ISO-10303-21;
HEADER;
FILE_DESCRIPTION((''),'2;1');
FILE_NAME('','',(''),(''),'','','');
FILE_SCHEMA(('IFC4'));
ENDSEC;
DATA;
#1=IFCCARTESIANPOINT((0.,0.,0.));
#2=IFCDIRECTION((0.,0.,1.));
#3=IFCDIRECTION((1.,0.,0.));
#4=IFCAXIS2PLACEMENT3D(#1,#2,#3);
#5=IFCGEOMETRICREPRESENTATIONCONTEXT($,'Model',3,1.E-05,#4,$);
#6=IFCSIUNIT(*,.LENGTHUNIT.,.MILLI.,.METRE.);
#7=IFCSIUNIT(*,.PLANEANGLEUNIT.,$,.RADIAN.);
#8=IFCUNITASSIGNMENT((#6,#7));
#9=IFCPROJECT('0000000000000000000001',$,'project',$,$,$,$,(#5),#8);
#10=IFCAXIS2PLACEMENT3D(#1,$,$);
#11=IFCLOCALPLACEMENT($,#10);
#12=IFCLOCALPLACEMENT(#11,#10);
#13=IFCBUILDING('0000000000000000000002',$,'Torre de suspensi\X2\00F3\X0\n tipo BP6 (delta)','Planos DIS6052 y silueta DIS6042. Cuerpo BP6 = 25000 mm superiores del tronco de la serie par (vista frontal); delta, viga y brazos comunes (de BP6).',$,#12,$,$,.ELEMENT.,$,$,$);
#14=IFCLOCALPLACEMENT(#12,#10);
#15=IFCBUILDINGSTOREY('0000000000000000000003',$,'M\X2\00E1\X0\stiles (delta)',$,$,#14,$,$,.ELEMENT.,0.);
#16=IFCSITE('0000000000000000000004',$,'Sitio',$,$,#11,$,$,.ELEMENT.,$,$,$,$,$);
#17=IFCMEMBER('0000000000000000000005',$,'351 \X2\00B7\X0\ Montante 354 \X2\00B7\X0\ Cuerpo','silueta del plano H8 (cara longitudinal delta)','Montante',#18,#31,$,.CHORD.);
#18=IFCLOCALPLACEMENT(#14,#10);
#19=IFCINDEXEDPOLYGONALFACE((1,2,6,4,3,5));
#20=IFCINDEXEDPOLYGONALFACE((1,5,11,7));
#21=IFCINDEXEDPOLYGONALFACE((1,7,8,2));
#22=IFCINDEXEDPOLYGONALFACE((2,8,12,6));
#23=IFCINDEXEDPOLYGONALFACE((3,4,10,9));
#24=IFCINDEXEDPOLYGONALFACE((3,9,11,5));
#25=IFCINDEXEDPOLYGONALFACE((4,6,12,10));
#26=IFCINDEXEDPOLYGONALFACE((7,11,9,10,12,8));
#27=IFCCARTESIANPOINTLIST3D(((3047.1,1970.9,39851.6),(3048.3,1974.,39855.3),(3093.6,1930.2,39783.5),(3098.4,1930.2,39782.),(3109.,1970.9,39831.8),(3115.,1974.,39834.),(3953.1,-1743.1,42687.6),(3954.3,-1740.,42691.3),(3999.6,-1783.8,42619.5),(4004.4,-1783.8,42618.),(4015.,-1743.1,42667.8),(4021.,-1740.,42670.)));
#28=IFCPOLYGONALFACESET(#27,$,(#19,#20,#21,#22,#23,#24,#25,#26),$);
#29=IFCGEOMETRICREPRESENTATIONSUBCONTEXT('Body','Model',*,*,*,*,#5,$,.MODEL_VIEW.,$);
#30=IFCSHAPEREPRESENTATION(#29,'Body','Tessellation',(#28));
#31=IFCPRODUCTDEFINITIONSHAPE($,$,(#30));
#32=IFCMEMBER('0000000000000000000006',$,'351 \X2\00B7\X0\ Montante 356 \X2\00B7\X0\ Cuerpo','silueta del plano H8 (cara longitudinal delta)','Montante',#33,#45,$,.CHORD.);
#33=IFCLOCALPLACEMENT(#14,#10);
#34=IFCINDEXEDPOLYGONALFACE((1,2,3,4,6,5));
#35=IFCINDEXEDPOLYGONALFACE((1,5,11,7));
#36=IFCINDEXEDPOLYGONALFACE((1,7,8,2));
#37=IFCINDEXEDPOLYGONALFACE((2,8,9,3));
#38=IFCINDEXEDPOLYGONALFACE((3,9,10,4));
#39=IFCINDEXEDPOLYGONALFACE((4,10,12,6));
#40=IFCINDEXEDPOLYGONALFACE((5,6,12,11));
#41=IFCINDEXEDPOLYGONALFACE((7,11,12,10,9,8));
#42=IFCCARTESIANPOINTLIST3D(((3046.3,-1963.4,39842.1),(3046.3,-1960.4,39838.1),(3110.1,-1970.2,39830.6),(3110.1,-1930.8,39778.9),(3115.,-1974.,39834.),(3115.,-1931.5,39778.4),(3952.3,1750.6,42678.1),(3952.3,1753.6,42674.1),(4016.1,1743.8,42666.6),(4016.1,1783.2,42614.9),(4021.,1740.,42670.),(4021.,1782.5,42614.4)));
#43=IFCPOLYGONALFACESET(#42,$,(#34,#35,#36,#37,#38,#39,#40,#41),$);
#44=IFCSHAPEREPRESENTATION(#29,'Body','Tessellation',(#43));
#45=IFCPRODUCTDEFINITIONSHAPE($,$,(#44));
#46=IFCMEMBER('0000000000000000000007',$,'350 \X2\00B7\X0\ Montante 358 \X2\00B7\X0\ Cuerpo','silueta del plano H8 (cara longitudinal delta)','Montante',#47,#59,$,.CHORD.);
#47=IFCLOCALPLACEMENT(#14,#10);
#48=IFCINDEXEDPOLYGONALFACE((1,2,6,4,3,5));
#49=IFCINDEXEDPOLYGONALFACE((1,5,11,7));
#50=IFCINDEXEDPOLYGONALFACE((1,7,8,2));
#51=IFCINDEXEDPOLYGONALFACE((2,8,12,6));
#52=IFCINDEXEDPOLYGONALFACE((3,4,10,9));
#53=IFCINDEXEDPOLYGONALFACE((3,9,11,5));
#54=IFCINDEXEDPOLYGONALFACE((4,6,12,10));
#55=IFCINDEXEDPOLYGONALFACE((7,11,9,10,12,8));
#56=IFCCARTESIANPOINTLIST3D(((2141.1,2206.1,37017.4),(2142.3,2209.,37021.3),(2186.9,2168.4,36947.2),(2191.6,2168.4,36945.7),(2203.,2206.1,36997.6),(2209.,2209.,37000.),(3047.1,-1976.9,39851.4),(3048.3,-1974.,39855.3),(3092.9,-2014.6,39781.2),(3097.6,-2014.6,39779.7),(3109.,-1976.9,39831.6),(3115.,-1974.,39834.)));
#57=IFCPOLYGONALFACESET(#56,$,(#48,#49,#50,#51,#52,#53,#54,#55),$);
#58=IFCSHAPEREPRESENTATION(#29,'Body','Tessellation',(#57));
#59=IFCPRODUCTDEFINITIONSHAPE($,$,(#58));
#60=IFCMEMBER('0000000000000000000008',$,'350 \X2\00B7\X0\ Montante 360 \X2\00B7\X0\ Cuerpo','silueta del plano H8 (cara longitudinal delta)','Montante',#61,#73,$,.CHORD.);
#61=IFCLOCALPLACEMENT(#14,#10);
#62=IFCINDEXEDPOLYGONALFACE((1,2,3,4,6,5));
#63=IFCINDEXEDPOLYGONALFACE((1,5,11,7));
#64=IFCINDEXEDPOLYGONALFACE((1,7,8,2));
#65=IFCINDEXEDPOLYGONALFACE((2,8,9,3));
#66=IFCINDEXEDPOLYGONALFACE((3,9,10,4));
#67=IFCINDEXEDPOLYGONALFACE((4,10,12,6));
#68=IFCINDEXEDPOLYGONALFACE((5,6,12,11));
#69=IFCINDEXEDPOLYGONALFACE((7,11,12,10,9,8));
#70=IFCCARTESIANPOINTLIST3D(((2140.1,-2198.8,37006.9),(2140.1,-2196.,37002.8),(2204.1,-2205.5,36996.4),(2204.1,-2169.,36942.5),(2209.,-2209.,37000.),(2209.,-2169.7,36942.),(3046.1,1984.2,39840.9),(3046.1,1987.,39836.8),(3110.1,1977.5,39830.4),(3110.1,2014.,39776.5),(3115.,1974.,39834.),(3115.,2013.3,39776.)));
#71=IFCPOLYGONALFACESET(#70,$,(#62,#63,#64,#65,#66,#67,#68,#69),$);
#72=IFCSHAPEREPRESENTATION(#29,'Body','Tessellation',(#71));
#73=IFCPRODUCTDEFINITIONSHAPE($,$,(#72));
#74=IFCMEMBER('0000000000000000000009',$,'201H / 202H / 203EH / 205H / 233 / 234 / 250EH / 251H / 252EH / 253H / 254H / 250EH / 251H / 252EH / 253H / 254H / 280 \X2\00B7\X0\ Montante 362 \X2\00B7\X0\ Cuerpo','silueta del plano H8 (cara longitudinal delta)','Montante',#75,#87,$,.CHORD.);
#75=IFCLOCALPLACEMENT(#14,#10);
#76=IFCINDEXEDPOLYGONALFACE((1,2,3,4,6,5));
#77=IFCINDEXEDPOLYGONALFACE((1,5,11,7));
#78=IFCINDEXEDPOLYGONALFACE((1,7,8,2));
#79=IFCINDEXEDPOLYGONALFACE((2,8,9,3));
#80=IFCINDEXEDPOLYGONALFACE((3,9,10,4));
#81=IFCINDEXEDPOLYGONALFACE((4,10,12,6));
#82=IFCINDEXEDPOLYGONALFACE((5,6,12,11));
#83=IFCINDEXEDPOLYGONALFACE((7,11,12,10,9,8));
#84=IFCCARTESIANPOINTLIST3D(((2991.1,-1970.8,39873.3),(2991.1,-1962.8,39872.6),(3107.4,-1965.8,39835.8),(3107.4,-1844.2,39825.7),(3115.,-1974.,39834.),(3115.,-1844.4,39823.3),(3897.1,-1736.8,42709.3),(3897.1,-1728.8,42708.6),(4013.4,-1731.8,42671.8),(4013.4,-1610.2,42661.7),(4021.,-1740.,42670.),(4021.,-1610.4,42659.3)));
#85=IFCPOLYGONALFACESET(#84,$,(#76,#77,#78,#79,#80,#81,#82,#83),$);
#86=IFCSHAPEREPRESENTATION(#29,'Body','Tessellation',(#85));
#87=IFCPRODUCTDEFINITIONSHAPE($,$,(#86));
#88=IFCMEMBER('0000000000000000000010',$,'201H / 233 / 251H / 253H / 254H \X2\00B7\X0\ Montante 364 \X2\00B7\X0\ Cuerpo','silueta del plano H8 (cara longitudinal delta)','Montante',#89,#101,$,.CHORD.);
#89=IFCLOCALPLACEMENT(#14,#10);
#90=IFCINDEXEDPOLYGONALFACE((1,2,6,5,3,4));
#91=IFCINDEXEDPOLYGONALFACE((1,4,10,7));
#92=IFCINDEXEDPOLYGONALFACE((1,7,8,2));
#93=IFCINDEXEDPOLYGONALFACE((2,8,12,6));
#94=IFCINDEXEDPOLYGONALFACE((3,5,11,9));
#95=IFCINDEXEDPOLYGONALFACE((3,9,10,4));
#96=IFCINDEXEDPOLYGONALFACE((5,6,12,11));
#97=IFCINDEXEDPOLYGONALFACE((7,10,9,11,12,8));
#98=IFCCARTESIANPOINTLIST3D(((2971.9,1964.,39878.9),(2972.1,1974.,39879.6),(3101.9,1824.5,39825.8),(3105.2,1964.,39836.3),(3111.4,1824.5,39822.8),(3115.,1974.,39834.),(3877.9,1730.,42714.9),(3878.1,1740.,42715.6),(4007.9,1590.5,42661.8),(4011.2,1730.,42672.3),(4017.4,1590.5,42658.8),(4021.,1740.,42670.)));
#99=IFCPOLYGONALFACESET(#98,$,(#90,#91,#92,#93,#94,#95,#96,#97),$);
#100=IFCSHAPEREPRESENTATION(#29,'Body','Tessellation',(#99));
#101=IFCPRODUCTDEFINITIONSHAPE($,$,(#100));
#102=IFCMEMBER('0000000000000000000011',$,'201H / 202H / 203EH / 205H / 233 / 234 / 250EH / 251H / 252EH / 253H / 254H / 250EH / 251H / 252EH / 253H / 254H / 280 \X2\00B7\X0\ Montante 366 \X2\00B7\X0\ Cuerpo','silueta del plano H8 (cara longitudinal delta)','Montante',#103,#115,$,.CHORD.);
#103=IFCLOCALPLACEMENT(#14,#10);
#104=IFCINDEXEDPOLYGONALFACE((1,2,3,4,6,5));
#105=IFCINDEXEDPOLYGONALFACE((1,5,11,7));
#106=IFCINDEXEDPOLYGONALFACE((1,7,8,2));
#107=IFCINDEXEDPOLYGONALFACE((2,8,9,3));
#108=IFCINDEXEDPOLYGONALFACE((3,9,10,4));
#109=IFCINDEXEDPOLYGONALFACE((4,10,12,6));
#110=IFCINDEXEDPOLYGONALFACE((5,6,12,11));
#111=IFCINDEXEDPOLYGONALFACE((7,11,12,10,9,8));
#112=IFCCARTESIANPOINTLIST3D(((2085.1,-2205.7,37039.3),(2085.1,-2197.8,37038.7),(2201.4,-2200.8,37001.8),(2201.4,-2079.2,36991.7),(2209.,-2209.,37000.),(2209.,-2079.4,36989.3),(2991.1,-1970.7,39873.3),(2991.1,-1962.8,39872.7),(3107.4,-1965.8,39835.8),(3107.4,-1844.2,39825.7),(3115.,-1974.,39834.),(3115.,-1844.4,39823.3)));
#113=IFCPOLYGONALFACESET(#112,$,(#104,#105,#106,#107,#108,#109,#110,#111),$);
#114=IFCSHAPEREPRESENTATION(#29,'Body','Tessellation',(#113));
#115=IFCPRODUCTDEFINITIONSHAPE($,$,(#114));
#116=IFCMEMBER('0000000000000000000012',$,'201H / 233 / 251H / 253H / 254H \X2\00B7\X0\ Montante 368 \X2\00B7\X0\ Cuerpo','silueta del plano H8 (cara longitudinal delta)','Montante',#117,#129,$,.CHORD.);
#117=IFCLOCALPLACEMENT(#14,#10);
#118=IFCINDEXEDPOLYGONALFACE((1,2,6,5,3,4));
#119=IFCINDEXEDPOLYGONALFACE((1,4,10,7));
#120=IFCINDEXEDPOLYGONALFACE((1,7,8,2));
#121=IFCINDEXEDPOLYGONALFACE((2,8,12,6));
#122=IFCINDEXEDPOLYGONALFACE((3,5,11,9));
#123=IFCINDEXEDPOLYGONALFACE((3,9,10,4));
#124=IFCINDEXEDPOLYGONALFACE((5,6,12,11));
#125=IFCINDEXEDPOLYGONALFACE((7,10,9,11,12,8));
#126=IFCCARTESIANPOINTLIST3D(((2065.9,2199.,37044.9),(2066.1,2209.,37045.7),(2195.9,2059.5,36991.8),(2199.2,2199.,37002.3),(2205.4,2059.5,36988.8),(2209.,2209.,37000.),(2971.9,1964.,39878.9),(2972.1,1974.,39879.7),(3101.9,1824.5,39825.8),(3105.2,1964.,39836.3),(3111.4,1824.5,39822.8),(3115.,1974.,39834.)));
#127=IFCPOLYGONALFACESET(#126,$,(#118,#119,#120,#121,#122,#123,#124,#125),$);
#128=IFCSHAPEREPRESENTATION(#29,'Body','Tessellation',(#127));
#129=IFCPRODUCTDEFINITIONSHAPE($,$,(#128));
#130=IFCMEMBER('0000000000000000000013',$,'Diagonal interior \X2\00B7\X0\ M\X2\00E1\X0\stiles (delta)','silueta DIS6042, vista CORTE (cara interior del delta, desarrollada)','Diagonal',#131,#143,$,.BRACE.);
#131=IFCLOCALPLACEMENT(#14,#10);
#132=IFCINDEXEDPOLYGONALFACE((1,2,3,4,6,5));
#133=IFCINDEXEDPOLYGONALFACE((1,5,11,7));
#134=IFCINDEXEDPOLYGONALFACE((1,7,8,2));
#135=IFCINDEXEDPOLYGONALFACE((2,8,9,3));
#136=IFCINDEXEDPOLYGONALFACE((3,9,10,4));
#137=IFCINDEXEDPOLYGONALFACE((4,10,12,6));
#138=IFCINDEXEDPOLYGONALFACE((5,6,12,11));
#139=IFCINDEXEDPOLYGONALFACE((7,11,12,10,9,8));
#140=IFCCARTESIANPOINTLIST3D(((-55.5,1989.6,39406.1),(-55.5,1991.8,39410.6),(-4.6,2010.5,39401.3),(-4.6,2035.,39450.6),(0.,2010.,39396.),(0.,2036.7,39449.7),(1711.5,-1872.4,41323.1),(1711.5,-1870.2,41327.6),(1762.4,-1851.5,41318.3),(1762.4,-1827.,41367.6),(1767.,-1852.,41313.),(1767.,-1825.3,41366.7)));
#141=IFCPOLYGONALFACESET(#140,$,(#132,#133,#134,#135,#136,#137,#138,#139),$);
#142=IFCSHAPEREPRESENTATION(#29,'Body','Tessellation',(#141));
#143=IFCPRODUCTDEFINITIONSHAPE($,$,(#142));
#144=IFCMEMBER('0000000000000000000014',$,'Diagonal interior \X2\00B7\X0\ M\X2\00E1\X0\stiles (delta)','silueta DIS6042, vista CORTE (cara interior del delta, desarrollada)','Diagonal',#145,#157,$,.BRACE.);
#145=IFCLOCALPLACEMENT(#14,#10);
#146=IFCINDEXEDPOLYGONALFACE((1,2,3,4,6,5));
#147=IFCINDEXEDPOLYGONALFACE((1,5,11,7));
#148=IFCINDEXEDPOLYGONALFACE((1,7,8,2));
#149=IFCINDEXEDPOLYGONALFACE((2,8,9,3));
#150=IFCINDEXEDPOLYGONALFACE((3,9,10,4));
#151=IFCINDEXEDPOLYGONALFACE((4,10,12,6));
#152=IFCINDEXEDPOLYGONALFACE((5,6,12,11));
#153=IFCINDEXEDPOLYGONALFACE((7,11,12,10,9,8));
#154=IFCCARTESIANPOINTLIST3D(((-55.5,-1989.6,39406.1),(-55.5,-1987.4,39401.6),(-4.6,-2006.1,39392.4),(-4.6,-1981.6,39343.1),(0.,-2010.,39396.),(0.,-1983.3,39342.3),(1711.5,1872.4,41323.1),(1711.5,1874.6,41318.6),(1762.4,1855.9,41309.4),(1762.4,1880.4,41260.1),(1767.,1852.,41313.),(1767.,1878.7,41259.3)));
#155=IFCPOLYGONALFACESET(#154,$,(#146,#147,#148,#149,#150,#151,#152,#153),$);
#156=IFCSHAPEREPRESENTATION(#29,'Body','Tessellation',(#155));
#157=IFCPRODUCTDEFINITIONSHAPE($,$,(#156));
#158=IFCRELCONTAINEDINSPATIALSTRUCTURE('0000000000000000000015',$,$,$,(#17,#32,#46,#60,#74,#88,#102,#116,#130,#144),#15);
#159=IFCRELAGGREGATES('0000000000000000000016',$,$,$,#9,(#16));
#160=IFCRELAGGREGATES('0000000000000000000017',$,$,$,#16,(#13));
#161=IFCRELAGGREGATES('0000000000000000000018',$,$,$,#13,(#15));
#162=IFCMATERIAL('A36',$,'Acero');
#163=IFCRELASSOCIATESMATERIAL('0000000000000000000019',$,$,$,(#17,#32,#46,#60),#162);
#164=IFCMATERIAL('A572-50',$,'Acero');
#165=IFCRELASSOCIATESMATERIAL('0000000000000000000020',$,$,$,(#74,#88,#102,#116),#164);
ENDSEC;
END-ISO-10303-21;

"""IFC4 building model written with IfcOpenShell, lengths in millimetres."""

from ifc_helpers import new_model, si_unit, frame, frame_2d, origin, origin_with_axes, place, context, subcontext, project, spatial, l_section, extrude, material, element, save


model = new_model("IFC4")

# Units and contexts
model_context = context("Model", 3, precision=1e-05, world=origin_with_axes())
body_context = subcontext(model_context, "Body", "Model", "MODEL_VIEW")
ifc_project = project(units=[si_unit("LENGTHUNIT", "METRE", prefix="MILLI"), si_unit("PLANEANGLEUNIT", "RADIAN")], contexts=[model_context])

# Site, building, storey
site_placement = place(None, origin())
site = spatial("IfcSite", under=ifc_project, at=site_placement, Name="Sitio", CompositionType="ELEMENT")
building_placement = place(site_placement, origin())
building = spatial("IfcBuilding", under=site, at=building_placement, Name="Torre de suspensión tipo BP6 (delta)", Description="Planos DIS6052 y silueta DIS6042. Cuerpo BP6 = 25000 mm superiores del tronco de la serie par (vista frontal); delta, viga y brazos comunes (de BP6).", CompositionType="ELEMENT")
storey_placement = place(building_placement, origin())
storey = spatial("IfcBuildingStorey", under=building, at=storey_placement, Name="Mástiles (delta)", CompositionType="ELEMENT", Elevation=0.0)

# Members
ifc_material_1 = material(Name="A572-50", Category="Acero")
ifc_material_2 = material(Name="A36", Category="Acero")
for number, where, z_axis, x_axis, name in (
    (1, (4021.0, -1740.0, 42670.0), (-0.190336, 0.780253, -0.595799), (-0.237441, -0.625464, -0.743248), "351 · Montante 354 · Cuerpo"),
    (2, (4021.0, 1740.0, 42670.0), (-0.190336, -0.780253, -0.595799), (-0.981719, 0.151276, 0.115514), "351 · Montante 356 · Cuerpo"),
):
    element("IfcMember", number, at=place(storey_placement, frame(where, z_axis=z_axis, x_axis=x_axis)), inside=storey, material=ifc_material_2, Name=name, Description="silueta del plano H8 (cara longitudinal delta)", ObjectType="Montante", PredefinedType="CHORD", context=body_context, shape_type="SweptSolid", body=[
        extrude(l_section(Depth=70.0, Width=70.0, Thickness=5.0, at=frame_2d((35.0, 35.0))), None, (0.0, 0.0, 1.0), 4760.0),
    ])
for number, where, z_axis, x_axis, name in (
    (3, (3115.0, -1974.0, 39834.0), (-0.176498, 0.814889, -0.552091), (-0.24814, -0.579617, -0.77619), "350 · Montante 358 · Cuerpo"),
    (4, (3115.0, 1974.0, 39834.0), (-0.176498, -0.814889, -0.552091), (-0.984301, 0.14612, 0.098997), "350 · Montante 360 · Cuerpo"),
):
    element("IfcMember", number, at=place(storey_placement, frame(where, z_axis=z_axis, x_axis=x_axis)), inside=storey, material=ifc_material_2, Name=name, Description="silueta del plano H8 (cara longitudinal delta)", ObjectType="Montante", PredefinedType="CHORD", context=body_context, shape_type="SweptSolid", body=[
        extrude(l_section(Depth=70.0, Width=70.0, Thickness=5.0, at=frame_2d((35.0, 35.0))), None, (0.0, 0.0, 1.0), 5133.2),
    ])
member_1_placement = place(storey_placement, frame((4021.0, -1740.0, 42670.0), z_axis=(-0.303377, -0.078356, -0.949644), x_axis=(-0.952871, 0.024947, 0.302349)))
element("IfcMember", 5, at=member_1_placement, inside=storey, material=ifc_material_1, Name="201H / 202H / 203EH / 205H / 233 / 234 / 250EH / 251H / 252EH / 253H / 254H / 250EH / 251H / 252EH / 253H / 254H / 280 · Montante 362 · Cuerpo", Description="silueta del plano H8 (cara longitudinal delta)", ObjectType="Montante", PredefinedType="CHORD", context=body_context, shape_type="SweptSolid", body=[
    extrude(l_section(Depth=130.0, Width=130.0, Thickness=8.0, at=frame_2d((65.0, 65.0))), None, (0.0, 0.0, 1.0), 2986.4),
])
member_2_placement = place(storey_placement, frame((4021.0, 1740.0, 42670.0), z_axis=(-0.303377, 0.078356, -0.949644), x_axis=(-0.023845, -0.996925, -0.074639)))
element("IfcMember", 6, at=member_2_placement, inside=storey, material=ifc_material_1, Name="201H / 233 / 251H / 253H / 254H · Montante 364 · Cuerpo", Description="silueta del plano H8 (cara longitudinal delta)", ObjectType="Montante", PredefinedType="CHORD", context=body_context, shape_type="SweptSolid", body=[
    extrude(l_section(Depth=150.0, Width=150.0, Thickness=10.0, at=frame_2d((75.0, 75.0))), None, (0.0, 0.0, 1.0), 2986.4),
])
member_3_placement = place(storey_placement, frame((3115.0, -1974.0, 39834.0), z_axis=(-0.303562, -0.078738, -0.949553), x_axis=(-0.952812, 0.025086, 0.302524)))
element("IfcMember", 7, at=member_3_placement, inside=storey, material=ifc_material_1, Name="201H / 202H / 203EH / 205H / 233 / 234 / 250EH / 251H / 252EH / 253H / 254H / 250EH / 251H / 252EH / 253H / 254H / 280 · Montante 366 · Cuerpo", Description="silueta del plano H8 (cara longitudinal delta)", ObjectType="Montante", PredefinedType="CHORD", context=body_context, shape_type="SweptSolid", body=[
    extrude(l_section(Depth=130.0, Width=130.0, Thickness=8.0, at=frame_2d((65.0, 65.0))), None, (0.0, 0.0, 1.0), 2984.6),
])
member_4_placement = place(storey_placement, frame((3115.0, 1974.0, 39834.0), z_axis=(-0.303562, 0.078738, -0.949553), x_axis=(-0.023976, -0.996895, -0.074999)))
element("IfcMember", 8, at=member_4_placement, inside=storey, material=ifc_material_1, Name="201H / 233 / 251H / 253H / 254H · Montante 368 · Cuerpo", Description="silueta del plano H8 (cara longitudinal delta)", ObjectType="Montante", PredefinedType="CHORD", context=body_context, shape_type="SweptSolid", body=[
    extrude(l_section(Depth=150.0, Width=150.0, Thickness=10.0, at=frame_2d((75.0, 75.0))), None, (0.0, 0.0, 1.0), 2984.6),
])
for number, where, z_axis, x_axis, name in (
    (9, (1767.0, -1852.0, 41313.0), (-0.379214, 0.82882, -0.411405), (-0.925309, -0.33967, 0.168604), "Diagonal interior · Mástiles (delta)"),
    (10, (1767.0, 1852.0, 41313.0), (-0.379214, -0.82882, -0.411405), (-0.925309, 0.33967, 0.168604), "Diagonal interior · Mástiles (delta)"),
):
    element("IfcMember", number, at=place(storey_placement, frame(where, z_axis=z_axis, x_axis=x_axis)), inside=storey, Name=name, Description="silueta DIS6042, vista CORTE (cara interior del delta, desarrollada)", ObjectType="Diagonal", PredefinedType="BRACE", context=body_context, shape_type="SweptSolid", body=[
        extrude(l_section(Depth=60.0, Width=60.0, Thickness=5.0, at=frame_2d((30.0, 30.0))), None, (0.0, 0.0, 1.0), 4659.6),
    ])

save(model, "model.ifc")
